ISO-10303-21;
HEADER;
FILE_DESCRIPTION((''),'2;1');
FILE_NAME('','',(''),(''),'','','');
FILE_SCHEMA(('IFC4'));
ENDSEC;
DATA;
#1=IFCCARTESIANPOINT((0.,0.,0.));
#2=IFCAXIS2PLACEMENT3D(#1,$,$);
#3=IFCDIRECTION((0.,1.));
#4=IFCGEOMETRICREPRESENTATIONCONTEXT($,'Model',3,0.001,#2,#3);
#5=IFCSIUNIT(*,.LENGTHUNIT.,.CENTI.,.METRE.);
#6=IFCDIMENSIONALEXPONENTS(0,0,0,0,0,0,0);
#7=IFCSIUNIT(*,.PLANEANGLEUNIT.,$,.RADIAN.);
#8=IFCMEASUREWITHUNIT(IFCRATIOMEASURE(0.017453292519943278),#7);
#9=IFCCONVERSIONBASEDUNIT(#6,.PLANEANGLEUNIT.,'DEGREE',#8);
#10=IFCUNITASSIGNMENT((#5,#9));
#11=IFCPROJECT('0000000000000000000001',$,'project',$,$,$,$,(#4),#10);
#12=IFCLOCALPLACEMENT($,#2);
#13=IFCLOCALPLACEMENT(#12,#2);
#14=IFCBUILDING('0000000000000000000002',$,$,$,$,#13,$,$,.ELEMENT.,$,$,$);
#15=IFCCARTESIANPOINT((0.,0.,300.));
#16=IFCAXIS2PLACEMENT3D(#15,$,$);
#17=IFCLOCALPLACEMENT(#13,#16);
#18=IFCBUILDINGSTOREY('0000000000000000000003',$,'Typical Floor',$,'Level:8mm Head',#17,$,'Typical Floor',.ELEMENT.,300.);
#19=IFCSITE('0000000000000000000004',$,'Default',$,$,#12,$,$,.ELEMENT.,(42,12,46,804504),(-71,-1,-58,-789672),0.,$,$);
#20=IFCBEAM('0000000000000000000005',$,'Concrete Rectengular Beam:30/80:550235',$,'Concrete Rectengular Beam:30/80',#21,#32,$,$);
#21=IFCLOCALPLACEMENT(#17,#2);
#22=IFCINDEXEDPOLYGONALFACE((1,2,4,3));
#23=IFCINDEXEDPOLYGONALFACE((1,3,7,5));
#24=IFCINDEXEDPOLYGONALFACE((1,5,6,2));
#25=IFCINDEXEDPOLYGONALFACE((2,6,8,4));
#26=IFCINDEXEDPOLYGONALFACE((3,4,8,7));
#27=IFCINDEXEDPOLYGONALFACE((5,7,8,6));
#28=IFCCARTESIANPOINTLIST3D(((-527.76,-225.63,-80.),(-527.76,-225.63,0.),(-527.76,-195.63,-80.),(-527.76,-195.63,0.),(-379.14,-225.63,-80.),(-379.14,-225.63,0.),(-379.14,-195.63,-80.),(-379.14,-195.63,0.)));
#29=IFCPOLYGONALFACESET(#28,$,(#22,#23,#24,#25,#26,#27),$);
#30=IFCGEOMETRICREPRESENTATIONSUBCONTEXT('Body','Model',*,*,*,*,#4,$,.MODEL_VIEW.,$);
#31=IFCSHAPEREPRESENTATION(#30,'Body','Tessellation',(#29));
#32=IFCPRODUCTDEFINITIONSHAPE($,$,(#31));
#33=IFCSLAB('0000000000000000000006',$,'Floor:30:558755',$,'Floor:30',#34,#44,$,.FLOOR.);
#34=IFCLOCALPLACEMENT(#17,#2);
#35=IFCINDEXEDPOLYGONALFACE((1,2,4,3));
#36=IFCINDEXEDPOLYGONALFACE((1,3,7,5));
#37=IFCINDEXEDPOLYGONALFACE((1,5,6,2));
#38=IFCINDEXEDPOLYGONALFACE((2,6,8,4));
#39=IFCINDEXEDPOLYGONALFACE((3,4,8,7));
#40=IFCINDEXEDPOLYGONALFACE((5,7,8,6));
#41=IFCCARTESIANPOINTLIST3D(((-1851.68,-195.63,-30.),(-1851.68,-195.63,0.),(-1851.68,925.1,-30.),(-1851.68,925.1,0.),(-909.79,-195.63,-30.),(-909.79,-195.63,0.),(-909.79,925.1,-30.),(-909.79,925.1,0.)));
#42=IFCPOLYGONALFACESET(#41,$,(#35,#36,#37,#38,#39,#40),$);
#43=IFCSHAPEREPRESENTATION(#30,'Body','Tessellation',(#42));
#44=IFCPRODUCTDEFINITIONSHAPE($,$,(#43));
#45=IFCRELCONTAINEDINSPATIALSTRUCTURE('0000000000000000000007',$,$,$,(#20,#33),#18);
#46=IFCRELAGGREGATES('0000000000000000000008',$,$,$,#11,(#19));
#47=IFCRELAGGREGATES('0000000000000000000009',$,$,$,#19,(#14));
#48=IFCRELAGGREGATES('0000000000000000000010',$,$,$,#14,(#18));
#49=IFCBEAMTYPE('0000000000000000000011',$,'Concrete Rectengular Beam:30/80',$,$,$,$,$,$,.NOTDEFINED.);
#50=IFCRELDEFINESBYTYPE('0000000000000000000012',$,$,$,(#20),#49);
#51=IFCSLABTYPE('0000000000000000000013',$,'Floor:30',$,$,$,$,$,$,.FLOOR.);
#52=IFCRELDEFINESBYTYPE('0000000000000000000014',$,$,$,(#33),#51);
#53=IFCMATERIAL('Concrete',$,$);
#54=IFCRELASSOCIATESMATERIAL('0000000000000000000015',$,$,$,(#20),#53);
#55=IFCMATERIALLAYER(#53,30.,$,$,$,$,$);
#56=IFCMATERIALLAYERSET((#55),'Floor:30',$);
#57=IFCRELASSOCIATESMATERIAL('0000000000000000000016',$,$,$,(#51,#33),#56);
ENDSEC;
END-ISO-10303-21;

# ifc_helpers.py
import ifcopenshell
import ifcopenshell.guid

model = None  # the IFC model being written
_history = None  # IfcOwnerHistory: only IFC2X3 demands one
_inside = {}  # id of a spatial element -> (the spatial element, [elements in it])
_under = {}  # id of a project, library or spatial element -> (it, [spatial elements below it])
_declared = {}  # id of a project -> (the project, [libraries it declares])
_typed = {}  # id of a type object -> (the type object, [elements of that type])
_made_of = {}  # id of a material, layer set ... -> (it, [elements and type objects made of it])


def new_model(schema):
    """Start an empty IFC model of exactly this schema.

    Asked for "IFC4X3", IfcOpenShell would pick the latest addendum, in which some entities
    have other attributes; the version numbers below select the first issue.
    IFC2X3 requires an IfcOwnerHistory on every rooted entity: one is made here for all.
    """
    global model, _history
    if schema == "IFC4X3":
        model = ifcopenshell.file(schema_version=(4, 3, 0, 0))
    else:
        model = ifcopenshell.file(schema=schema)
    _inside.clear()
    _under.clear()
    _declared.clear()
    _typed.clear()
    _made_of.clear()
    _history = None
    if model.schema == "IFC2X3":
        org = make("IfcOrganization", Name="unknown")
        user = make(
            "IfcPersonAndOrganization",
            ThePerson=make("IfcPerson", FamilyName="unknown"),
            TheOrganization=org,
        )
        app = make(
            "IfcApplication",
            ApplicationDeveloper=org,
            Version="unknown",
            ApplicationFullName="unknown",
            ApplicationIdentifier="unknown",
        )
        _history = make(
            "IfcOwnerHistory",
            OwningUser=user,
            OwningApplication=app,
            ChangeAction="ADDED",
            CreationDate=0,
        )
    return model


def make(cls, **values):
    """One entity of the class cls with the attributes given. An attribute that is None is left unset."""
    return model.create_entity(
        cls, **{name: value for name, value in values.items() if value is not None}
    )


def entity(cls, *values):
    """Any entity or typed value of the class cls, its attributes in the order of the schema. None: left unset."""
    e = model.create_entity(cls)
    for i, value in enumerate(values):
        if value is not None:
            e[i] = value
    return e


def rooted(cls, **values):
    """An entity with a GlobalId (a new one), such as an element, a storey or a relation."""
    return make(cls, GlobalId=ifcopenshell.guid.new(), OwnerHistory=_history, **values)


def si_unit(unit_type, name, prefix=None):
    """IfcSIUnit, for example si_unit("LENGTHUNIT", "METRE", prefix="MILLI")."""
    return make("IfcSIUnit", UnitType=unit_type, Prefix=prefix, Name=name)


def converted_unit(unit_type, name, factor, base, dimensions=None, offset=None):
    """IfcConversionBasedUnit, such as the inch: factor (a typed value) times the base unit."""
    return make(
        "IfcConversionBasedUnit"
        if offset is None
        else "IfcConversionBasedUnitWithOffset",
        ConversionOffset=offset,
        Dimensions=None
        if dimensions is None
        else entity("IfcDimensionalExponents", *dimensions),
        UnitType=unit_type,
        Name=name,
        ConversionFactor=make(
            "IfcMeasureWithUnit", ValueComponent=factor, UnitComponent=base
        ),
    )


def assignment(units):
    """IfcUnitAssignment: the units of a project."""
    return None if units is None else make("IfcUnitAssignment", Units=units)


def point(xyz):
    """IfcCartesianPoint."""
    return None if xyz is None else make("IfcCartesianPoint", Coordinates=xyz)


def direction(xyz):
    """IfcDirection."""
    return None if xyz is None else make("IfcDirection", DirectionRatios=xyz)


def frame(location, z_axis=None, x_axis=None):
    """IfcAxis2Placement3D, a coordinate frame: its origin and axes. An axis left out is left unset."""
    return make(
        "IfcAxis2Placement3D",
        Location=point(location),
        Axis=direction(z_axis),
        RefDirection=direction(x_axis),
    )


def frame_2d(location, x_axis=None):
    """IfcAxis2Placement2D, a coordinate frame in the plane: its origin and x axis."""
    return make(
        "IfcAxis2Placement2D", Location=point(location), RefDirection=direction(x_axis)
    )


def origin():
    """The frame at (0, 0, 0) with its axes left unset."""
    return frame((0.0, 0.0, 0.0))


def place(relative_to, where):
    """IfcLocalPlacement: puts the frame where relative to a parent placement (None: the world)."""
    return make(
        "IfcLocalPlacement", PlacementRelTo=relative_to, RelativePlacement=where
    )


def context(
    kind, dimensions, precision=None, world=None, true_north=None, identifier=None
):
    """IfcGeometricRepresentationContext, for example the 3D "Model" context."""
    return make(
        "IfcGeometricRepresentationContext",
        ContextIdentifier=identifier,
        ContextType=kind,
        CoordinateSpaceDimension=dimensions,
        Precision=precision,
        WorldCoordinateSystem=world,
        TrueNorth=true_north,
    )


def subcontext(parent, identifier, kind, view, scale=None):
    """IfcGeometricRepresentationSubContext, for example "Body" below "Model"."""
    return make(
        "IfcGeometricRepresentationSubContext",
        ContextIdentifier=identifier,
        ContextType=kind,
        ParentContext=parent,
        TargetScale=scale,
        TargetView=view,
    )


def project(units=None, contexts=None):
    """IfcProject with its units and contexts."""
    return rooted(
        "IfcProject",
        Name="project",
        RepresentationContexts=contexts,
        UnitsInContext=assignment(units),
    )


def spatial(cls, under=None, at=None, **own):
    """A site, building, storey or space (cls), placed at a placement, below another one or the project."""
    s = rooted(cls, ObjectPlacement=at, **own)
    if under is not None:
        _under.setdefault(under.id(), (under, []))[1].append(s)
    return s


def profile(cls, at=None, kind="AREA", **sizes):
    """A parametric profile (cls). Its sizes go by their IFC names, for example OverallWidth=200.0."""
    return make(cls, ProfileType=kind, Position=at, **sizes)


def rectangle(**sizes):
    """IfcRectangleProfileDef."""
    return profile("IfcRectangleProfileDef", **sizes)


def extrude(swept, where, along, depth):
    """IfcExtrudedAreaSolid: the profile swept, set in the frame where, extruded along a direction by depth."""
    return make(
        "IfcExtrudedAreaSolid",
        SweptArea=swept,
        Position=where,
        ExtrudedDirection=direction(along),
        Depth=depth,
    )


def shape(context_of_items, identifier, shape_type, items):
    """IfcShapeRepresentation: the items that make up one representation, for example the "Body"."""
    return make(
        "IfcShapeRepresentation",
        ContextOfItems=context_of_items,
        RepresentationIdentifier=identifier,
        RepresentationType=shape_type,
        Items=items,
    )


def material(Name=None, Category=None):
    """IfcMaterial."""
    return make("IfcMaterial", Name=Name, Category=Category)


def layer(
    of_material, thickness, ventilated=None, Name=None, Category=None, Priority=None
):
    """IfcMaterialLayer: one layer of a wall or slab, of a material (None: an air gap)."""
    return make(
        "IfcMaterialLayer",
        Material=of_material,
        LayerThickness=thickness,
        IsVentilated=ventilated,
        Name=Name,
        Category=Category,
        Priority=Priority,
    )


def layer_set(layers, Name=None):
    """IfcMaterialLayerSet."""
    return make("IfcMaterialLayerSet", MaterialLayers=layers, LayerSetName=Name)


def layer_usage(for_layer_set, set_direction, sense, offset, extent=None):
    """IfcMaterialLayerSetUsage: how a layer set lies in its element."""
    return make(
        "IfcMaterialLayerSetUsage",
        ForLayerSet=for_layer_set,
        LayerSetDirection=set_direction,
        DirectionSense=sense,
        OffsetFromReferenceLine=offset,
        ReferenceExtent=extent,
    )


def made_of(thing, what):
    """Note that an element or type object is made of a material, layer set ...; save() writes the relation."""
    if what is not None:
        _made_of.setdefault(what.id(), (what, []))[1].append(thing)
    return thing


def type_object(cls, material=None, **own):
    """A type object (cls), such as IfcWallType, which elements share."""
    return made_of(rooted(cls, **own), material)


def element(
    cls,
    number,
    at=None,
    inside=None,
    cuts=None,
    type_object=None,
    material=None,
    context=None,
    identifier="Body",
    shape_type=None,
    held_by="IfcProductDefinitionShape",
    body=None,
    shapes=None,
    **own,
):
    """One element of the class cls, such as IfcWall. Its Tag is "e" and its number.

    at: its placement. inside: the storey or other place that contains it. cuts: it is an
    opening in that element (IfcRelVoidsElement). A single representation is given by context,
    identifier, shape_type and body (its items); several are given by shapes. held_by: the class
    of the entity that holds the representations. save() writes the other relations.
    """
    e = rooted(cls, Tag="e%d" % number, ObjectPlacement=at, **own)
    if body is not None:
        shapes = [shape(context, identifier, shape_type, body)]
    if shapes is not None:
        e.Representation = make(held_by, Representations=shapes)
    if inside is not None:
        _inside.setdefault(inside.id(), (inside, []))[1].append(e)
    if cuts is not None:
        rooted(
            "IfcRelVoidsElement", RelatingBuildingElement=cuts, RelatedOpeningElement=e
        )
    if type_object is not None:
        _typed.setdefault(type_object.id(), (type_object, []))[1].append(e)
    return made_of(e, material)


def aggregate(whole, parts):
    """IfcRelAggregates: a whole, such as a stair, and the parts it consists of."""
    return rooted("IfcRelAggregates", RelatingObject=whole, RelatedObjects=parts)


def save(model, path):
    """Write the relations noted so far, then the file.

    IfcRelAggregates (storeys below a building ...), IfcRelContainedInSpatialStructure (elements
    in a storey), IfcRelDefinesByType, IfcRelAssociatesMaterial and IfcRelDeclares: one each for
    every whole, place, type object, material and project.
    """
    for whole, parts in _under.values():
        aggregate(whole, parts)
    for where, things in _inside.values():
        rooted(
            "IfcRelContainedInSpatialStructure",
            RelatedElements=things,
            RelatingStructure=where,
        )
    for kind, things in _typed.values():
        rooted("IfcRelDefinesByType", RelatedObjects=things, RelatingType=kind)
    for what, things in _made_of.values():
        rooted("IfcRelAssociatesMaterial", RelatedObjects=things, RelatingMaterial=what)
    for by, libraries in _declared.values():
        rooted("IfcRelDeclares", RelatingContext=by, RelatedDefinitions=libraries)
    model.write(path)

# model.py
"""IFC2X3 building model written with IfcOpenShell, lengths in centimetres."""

from ifc_helpers import new_model, entity, si_unit, converted_unit, direction, frame, frame_2d, origin, place, context, subcontext, project, spatial, rectangle, extrude, material, layer, layer_set, layer_usage, type_object, element, save


model = new_model("IFC2X3")

# Units and contexts
model_context = context("Model", 3, precision=0.001, world=origin(), true_north=direction((0.0, 1.0)))
body_context = subcontext(model_context, "Body", "Model", "MODEL_VIEW")
ifc_project = project(units=[si_unit("LENGTHUNIT", "METRE", prefix="CENTI"), converted_unit("PLANEANGLEUNIT", "DEGREE", entity("IfcRatioMeasure", 0.017453292519943278), si_unit("PLANEANGLEUNIT", "RADIAN"), dimensions=[0, 0, 0, 0, 0, 0, 0])], contexts=[model_context])

# Site, building, storey
site_placement = place(None, origin())
site = spatial("IfcSite", under=ifc_project, at=site_placement, Name="Default", CompositionType="ELEMENT", RefLatitude=(42, 12, 46, 804504), RefLongitude=(-71, -1, -58, -789672), RefElevation=0.0)
building_placement = place(site_placement, origin())
building = spatial("IfcBuilding", under=site, at=building_placement, CompositionType="ELEMENT")
storey_placement = place(building_placement, frame((0.0, 0.0, 300.0)))
storey = spatial("IfcBuildingStorey", under=building, at=storey_placement, Name="Typical Floor", ObjectType="Level:8mm Head", LongName="Typical Floor", CompositionType="ELEMENT", Elevation=300.0)

# Beam
ifc_material = material(Name="Concrete")
beam_type = type_object("IfcBeamType", Name="Concrete Rectengular Beam:30/80", PredefinedType="NOTDEFINED")
beam_1_placement = place(storey_placement, frame((-527.76, -210.63, 0.0)))
element("IfcBeam", 1, at=beam_1_placement, inside=storey, type_object=beam_type, material=ifc_material, Name="Concrete Rectengular Beam:30/80:550235", ObjectType="Concrete Rectengular Beam:30/80", context=body_context, shape_type="SweptSolid", body=[
    extrude(rectangle(XDim=80.0, YDim=30.0, at=frame_2d((0.0, 0.0), x_axis=(1.0, 0.0))), frame((0.0, 0.0, -40.0), z_axis=(1.0, 0.0, 0.0), x_axis=(0.0, 0.0, -1.0)), (0.0, 0.0, 1.0), 148.62),
])

# Slab
ifc_layer = layer(ifc_material, 30.0)
ifc_layer_set = layer_set([ifc_layer], Name="Floor:30")
ifc_layer_usage_1 = layer_usage(ifc_layer_set, "AXIS3", "POSITIVE", 0.0)
slab_type_1 = type_object("IfcSlabType", Name="Floor:30", PredefinedType="FLOOR", material=ifc_layer_set)
slab_1_placement = place(storey_placement, origin())
element("IfcSlab", 2, at=slab_1_placement, inside=storey, type_object=slab_type_1, material=ifc_layer_usage_1, Name="Floor:30:558755", ObjectType="Floor:30", PredefinedType="FLOOR", context=body_context, shape_type="SweptSolid", body=[
    extrude(rectangle(XDim=1120.73, YDim=941.89, at=frame_2d((0.0, 0.0), x_axis=(1.0, 0.0))), frame((-1380.74, 364.74, 0.0), z_axis=(0.0, 0.0, -1.0), x_axis=(0.0, 1.0, 0.0)), (0.0, 0.0, 1.0), 30.0),
])

save(model, "model.ifc")
